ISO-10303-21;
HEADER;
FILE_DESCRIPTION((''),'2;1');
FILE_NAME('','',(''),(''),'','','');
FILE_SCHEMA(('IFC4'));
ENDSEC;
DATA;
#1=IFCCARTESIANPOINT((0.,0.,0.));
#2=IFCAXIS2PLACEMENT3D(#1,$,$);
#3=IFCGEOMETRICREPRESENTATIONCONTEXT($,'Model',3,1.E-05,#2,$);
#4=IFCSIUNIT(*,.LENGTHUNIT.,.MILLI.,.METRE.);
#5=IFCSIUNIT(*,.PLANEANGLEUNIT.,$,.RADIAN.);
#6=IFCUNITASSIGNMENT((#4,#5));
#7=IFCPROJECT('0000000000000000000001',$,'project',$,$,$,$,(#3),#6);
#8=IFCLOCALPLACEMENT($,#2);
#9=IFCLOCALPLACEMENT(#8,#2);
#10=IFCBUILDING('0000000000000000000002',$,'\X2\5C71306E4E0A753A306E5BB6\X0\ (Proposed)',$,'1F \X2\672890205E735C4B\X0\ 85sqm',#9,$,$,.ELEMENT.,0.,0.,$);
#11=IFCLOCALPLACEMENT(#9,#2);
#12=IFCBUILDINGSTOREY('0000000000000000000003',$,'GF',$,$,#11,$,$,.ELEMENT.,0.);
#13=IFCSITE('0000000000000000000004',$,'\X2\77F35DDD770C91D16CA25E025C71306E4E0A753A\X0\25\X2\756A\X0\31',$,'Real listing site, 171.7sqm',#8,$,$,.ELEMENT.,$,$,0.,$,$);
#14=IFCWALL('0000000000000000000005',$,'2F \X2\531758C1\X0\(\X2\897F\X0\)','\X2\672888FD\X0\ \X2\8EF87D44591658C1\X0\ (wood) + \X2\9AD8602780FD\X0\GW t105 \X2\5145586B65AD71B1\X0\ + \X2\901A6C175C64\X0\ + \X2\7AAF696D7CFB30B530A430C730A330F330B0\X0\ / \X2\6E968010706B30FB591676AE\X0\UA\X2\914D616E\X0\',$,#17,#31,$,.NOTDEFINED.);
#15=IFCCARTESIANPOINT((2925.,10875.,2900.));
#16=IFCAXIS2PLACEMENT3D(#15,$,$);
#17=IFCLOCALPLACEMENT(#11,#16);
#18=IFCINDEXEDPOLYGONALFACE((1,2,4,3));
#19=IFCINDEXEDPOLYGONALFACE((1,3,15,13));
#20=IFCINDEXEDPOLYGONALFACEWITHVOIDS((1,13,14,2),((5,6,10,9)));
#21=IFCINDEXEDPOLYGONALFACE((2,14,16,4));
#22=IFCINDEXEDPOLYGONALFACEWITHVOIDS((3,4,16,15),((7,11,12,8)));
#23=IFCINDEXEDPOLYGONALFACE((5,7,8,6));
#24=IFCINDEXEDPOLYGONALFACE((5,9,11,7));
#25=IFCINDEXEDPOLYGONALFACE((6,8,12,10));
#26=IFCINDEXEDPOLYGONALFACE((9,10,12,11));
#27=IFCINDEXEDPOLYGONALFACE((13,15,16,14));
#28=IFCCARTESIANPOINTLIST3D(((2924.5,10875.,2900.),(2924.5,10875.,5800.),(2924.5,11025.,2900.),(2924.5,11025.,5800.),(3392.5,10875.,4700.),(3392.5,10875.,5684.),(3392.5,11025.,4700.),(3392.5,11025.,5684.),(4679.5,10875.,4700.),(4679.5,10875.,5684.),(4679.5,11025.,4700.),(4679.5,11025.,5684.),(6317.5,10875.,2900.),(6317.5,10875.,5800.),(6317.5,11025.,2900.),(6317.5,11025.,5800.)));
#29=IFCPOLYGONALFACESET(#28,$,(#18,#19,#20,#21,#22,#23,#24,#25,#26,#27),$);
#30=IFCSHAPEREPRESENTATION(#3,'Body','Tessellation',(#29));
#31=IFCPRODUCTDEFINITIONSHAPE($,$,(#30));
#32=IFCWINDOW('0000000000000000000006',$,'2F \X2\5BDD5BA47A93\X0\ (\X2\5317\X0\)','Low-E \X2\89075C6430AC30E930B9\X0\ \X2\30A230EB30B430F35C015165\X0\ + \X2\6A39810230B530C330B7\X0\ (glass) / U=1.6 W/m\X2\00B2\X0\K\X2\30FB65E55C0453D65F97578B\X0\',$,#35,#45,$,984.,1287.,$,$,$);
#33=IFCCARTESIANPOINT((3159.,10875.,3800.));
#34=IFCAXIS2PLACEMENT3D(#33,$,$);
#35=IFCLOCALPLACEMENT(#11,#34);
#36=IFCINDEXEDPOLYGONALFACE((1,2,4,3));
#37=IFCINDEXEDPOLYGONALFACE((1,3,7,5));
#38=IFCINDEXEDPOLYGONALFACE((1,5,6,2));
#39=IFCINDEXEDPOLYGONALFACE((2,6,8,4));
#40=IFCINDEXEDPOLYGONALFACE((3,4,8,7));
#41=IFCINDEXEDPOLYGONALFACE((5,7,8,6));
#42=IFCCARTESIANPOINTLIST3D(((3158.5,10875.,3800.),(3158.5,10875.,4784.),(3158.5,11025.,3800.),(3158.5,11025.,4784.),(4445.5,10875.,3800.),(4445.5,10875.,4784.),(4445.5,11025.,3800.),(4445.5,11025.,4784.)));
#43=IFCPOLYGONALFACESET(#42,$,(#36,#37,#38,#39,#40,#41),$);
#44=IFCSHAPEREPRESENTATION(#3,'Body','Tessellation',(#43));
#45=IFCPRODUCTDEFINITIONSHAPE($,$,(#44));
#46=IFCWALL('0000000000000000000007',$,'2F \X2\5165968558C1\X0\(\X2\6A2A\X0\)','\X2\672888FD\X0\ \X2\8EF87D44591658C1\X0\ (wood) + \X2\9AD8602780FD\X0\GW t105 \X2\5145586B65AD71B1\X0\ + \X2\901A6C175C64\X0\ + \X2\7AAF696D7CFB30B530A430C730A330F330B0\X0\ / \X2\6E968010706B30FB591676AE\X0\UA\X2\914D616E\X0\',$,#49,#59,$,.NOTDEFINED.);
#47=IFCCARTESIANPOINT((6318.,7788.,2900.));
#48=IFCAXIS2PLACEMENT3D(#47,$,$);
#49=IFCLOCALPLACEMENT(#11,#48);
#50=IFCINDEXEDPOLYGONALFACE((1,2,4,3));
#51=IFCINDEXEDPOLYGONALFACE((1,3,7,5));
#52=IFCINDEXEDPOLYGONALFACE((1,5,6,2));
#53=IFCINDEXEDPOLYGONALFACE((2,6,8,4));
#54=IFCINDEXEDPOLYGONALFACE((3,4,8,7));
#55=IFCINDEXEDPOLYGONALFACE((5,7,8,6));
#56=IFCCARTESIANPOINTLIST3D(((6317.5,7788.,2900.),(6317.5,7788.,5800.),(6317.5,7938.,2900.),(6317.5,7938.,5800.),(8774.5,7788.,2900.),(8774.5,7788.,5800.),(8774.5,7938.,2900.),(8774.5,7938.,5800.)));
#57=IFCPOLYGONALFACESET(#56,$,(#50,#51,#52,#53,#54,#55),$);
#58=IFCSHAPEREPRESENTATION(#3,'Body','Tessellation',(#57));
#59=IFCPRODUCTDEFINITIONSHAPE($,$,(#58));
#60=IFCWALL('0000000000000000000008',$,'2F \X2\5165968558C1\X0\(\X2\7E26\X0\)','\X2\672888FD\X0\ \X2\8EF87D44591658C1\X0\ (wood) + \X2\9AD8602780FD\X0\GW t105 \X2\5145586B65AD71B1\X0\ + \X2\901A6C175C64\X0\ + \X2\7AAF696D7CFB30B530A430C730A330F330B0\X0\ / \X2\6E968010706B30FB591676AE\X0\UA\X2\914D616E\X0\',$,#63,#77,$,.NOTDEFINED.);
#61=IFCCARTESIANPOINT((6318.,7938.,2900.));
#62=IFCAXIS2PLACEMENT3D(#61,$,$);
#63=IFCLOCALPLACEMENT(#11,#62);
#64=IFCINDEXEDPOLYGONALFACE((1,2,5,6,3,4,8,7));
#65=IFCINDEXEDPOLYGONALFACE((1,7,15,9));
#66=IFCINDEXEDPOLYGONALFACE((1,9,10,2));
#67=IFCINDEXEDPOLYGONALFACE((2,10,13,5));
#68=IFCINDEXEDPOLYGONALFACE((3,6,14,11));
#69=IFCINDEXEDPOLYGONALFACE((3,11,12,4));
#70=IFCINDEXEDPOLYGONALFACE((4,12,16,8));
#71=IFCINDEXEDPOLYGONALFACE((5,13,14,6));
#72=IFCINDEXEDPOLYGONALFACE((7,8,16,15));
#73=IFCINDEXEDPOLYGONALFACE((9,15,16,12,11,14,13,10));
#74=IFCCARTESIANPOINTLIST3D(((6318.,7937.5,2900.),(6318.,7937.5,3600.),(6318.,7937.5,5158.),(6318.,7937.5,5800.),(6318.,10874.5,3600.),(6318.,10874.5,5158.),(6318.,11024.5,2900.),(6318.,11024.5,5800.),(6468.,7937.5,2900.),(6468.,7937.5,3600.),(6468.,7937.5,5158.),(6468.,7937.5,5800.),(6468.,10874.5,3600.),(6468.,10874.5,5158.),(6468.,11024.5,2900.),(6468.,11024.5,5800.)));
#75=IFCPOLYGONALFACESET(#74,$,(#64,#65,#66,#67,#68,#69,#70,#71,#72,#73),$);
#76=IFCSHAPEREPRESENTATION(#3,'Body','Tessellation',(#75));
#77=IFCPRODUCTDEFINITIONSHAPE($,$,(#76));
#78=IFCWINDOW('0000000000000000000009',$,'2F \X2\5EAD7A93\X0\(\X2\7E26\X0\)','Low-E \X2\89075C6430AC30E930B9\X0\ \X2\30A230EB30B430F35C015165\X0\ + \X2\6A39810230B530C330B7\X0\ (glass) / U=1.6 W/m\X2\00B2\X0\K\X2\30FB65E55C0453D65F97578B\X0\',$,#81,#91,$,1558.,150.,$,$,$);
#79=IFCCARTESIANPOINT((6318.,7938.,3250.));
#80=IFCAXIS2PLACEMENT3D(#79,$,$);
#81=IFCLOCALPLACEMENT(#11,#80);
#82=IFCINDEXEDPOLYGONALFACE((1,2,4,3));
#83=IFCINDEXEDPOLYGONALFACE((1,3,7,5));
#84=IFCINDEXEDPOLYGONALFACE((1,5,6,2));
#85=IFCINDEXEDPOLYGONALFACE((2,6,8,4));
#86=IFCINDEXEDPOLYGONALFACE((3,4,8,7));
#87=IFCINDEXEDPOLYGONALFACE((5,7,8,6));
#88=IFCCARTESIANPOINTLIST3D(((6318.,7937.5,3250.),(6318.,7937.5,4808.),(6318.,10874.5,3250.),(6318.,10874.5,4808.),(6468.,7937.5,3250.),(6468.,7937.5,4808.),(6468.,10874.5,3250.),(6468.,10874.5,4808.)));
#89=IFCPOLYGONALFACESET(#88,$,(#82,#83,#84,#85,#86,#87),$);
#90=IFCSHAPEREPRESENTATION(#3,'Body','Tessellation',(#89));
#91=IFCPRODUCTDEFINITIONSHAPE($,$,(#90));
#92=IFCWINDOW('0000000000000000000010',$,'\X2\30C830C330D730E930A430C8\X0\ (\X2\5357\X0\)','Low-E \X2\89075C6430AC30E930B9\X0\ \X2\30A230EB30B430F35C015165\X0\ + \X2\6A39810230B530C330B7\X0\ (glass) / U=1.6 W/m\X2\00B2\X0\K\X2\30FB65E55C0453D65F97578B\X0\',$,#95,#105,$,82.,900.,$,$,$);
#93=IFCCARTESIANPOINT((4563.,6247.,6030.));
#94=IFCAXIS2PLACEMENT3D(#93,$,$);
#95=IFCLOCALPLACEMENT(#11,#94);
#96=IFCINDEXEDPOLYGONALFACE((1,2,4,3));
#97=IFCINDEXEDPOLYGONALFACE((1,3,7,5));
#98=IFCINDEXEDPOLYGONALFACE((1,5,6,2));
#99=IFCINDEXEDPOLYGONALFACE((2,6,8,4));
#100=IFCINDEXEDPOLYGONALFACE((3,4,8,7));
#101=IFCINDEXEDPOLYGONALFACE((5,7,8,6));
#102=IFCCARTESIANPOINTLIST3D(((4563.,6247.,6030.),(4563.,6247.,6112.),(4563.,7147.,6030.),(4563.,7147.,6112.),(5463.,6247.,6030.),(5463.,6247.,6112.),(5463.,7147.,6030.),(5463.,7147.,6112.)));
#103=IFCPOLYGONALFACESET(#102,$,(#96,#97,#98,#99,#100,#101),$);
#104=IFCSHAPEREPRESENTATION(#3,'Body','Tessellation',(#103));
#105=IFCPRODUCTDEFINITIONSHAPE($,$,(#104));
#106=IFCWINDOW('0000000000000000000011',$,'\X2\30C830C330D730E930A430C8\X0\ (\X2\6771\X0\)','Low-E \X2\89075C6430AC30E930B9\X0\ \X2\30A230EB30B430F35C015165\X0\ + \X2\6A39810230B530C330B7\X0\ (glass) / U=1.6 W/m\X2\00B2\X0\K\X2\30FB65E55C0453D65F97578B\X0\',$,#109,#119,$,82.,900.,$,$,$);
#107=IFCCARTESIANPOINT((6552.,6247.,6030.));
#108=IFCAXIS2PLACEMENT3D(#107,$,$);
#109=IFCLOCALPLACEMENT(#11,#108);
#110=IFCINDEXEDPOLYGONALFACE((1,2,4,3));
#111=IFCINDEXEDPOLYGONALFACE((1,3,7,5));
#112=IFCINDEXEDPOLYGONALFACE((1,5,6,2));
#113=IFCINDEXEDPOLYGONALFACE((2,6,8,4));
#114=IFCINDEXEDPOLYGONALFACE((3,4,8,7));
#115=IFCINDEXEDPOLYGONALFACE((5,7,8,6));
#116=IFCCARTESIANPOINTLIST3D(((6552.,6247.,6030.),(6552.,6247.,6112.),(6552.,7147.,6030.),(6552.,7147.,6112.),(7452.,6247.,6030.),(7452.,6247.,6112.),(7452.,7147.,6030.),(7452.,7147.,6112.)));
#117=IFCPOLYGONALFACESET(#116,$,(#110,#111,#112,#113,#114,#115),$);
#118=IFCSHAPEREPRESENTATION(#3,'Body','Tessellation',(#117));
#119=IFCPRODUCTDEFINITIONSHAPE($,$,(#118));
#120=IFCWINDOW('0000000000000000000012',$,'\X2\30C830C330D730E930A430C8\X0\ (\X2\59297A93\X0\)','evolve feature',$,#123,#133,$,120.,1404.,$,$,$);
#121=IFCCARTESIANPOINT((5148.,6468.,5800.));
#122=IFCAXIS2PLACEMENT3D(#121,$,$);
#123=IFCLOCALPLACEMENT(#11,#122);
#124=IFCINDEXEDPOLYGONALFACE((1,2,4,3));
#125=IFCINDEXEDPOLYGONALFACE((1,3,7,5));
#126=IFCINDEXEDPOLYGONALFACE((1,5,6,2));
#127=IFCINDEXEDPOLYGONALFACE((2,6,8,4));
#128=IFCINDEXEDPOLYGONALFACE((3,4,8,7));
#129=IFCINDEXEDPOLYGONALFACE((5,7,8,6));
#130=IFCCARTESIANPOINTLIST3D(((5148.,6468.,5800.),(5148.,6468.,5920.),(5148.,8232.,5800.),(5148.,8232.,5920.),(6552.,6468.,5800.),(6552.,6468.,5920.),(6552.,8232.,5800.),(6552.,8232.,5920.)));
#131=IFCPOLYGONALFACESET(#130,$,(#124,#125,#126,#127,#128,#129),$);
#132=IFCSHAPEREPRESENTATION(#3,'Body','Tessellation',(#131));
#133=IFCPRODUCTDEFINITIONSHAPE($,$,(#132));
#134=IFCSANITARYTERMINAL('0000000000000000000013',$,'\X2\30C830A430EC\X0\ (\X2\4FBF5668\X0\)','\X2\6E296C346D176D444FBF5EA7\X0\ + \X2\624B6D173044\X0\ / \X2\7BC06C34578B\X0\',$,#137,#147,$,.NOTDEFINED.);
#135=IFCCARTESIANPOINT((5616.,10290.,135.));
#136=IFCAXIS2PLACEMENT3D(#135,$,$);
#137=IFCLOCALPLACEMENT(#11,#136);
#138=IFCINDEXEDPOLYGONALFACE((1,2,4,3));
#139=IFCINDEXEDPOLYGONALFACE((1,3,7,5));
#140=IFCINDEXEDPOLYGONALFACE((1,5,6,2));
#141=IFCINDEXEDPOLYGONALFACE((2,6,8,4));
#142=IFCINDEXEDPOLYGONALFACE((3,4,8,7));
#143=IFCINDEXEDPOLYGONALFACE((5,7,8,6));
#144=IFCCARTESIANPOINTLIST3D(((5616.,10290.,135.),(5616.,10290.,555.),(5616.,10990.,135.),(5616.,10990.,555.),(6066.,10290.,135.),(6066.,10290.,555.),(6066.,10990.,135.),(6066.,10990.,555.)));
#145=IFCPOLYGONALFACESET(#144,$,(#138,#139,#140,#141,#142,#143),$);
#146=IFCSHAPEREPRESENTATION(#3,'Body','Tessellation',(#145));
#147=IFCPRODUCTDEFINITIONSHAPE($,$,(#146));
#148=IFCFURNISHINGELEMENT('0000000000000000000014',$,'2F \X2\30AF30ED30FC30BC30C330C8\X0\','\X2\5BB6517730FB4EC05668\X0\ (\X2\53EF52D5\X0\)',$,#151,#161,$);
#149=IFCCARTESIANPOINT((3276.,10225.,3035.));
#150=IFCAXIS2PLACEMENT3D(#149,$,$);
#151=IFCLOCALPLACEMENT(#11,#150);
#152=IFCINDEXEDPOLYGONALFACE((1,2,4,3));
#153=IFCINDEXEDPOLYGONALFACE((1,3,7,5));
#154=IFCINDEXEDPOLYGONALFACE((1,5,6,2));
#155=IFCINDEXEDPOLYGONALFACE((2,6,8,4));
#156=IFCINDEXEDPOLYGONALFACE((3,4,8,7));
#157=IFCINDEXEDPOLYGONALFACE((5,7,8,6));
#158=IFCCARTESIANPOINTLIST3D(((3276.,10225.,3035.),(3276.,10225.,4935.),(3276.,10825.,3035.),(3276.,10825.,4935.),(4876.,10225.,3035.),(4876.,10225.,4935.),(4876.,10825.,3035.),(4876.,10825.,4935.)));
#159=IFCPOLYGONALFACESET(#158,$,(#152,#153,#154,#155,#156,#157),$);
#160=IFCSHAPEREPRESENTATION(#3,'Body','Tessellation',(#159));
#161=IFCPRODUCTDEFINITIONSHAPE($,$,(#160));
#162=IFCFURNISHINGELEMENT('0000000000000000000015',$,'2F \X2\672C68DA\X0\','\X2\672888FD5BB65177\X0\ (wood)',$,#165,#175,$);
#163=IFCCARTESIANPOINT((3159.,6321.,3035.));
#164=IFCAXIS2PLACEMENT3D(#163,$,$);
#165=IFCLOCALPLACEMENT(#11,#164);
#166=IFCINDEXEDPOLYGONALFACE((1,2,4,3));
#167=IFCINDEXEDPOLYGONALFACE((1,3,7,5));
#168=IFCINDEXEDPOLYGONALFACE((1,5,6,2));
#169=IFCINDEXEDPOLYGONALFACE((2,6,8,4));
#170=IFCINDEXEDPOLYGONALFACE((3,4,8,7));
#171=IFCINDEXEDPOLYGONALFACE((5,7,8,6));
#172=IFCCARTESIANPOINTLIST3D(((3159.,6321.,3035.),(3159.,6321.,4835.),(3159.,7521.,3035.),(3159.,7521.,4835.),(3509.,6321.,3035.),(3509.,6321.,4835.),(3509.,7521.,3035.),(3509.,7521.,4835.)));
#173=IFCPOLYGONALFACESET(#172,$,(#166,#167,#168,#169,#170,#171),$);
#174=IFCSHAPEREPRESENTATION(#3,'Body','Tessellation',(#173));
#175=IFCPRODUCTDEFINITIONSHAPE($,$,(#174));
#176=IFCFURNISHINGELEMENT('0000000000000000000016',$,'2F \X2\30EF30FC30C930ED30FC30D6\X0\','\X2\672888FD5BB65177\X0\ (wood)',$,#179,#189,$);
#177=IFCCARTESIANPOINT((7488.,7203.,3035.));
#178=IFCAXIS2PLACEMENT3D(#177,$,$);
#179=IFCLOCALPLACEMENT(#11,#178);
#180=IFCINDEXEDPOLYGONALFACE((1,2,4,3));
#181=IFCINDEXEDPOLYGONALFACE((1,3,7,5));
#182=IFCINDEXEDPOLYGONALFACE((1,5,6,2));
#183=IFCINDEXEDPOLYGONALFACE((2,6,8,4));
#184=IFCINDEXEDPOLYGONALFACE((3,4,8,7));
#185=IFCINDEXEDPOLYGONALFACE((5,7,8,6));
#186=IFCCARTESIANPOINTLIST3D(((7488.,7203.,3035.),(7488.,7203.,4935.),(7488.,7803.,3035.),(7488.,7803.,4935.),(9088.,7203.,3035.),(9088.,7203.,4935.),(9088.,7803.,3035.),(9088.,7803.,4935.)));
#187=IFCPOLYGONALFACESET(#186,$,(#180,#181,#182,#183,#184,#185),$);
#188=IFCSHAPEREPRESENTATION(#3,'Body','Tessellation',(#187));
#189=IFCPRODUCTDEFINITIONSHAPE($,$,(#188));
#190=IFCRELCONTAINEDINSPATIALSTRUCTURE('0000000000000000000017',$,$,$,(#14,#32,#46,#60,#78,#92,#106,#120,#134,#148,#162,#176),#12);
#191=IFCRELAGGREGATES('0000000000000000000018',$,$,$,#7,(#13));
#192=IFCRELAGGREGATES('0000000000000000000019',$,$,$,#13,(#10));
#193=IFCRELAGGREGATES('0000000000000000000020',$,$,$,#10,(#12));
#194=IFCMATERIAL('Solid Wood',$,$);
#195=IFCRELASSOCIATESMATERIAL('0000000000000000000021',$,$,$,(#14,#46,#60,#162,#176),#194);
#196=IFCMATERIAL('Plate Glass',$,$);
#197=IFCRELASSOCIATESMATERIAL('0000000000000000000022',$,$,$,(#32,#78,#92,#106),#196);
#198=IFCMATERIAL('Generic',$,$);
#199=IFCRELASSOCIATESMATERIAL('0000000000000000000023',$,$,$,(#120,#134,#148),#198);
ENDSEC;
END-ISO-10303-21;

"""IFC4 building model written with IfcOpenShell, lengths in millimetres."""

from ifc_helpers import new_model, si_unit, frame, frame_2d, origin, place, context, project, spatial, rectangle, extrude, material, element, fill, save


model = new_model("IFC4")

# Units and contexts
model_context = context("Model", 3, precision=1e-05, world=origin())
ifc_project = project(units=[si_unit("LENGTHUNIT", "METRE", prefix="MILLI"), si_unit("PLANEANGLEUNIT", "RADIAN")], contexts=[model_context])

# Site, building, storey
site_placement = place(None, origin())
site = spatial("IfcSite", under=ifc_project, at=site_placement, Name="石川県金沢市山の上町25番31", ObjectType="Real listing site, 171.7sqm", CompositionType="ELEMENT", RefElevation=0.0)
building_placement = place(site_placement, origin())
building = spatial("IfcBuilding", under=site, at=building_placement, Name="山の上町の家 (Proposed)", ObjectType="1F 木造平屋 85sqm", CompositionType="ELEMENT", ElevationOfRefHeight=0.0, ElevationOfTerrain=0.0)
storey_placement = place(building_placement, origin())
storey = spatial("IfcBuildingStorey", under=building, at=storey_placement, Name="GF", CompositionType="ELEMENT", Elevation=0.0)

# Shared definitions
ifc_material_1 = material(Name="Solid Wood")

# Wall, opening, window
wall_1_placement = place(storey_placement, frame((2925.0, 10875.0, 2900.0)))
wall_1 = element("IfcWall", 1, at=wall_1_placement, inside=storey, material=ifc_material_1, Name="2F 北壁(西)", Description="木製 軸組外壁 (wood) + 高性能GW t105 充填断熱 + 通気層 + 窯業系サイディング / 準耐火・外皮UA配慮", PredefinedType="NOTDEFINED", context=model_context, shape_type="SweptSolid", body=[
    extrude(rectangle(XDim=3393.0, YDim=150.0, at=frame_2d((1696.0, 75.0))), frame((2925.0, 10875.0, 2900.0)), (0.0, 0.0, 1.0), 2900.0),
])
opening_1_placement = place(storey_placement, frame((3159.0, 10875.0, 3800.0)))
opening_1 = element("IfcOpeningElement", 2, at=opening_1_placement, cuts=wall_1, PredefinedType="NOTDEFINED", context=model_context, shape_type="SweptSolid", body=[
    extrude(rectangle(XDim=1287.0, YDim=150.0, at=frame_2d((643.0, 75.0))), frame((3159.0, 10875.0, 3800.0)), (0.0, 0.0, 1.0), 984.0),
])
ifc_material_2 = material(Name="Plate Glass")
window_1_placement = place(storey_placement, frame((3159.0, 10875.0, 3800.0)))
window_1 = element("IfcWindow", 3, at=window_1_placement, inside=storey, material=ifc_material_2, Name="2F 寝室窓 (北)", Description="Low-E 複層ガラス アルゴン封入 + 樹脂サッシ (glass) / U=1.6 W/m²K・日射取得型", OverallHeight=984.0, OverallWidth=1287.0, context=model_context, shape_type="SweptSolid", body=[
    extrude(rectangle(XDim=1287.0, YDim=150.0, at=frame_2d((643.0, 75.0))), frame((3159.0, 10875.0, 3800.0)), (0.0, 0.0, 1.0), 984.0),
])
fill(opening_1, window_1)

# Wall
wall_2_placement = place(storey_placement, frame((6318.0, 7788.0, 2900.0)))
element("IfcWall", 4, at=wall_2_placement, inside=storey, material=ifc_material_1, Name="2F 入隅壁(横)", Description="木製 軸組外壁 (wood) + 高性能GW t105 充填断熱 + 通気層 + 窯業系サイディング / 準耐火・外皮UA配慮", PredefinedType="NOTDEFINED", context=model_context, shape_type="SweptSolid", body=[
    extrude(rectangle(XDim=2457.0, YDim=150.0, at=frame_2d((1228.0, 75.0))), frame((6318.0, 7788.0, 2900.0)), (0.0, 0.0, 1.0), 2900.0),
])

# Wall, opening, window
wall_3_placement = place(storey_placement, frame((6318.0, 7938.0, 2900.0)))
wall_3 = element("IfcWall", 5, at=wall_3_placement, inside=storey, material=ifc_material_1, Name="2F 入隅壁(縦)", Description="木製 軸組外壁 (wood) + 高性能GW t105 充填断熱 + 通気層 + 窯業系サイディング / 準耐火・外皮UA配慮", PredefinedType="NOTDEFINED", context=model_context, shape_type="SweptSolid", body=[
    extrude(rectangle(XDim=150.0, YDim=3087.0, at=frame_2d((75.0, 1543.0))), frame((6318.0, 7938.0, 2900.0)), (0.0, 0.0, 1.0), 2900.0),
])
opening_2_placement = place(storey_placement, frame((6318.0, 7938.0, 3250.0)))
opening_2 = element("IfcOpeningElement", 6, at=opening_2_placement, cuts=wall_3, PredefinedType="NOTDEFINED", context=model_context, shape_type="SweptSolid", body=[
    extrude(rectangle(XDim=150.0, YDim=2937.0, at=frame_2d((75.0, 1468.0))), frame((6318.0, 7938.0, 3250.0)), (0.0, 0.0, 1.0), 1558.0),
])
window_2_placement = place(storey_placement, frame((6318.0, 7938.0, 3250.0)))
window_2 = element("IfcWindow", 7, at=window_2_placement, inside=storey, material=ifc_material_2, Name="2F 庭窓(縦)", Description="Low-E 複層ガラス アルゴン封入 + 樹脂サッシ (glass) / U=1.6 W/m²K・日射取得型", OverallHeight=1558.0, OverallWidth=150.0, context=model_context, shape_type="SweptSolid", body=[
    extrude(rectangle(XDim=150.0, YDim=2937.0, at=frame_2d((75.0, 1468.0))), frame((6318.0, 7938.0, 3250.0)), (0.0, 0.0, 1.0), 1558.0),
])
fill(opening_2, window_2)

# Windows
window_3_placement = place(storey_placement, frame((4563.0, 6247.0, 6030.0)))
element("IfcWindow", 8, at=window_3_placement, inside=storey, material=ifc_material_2, Name="トップライト (南)", Description="Low-E 複層ガラス アルゴン封入 + 樹脂サッシ (glass) / U=1.6 W/m²K・日射取得型", OverallHeight=82.0, OverallWidth=900.0, context=model_context, shape_type="SweptSolid", body=[
    extrude(rectangle(XDim=900.0, YDim=900.0, at=frame_2d((450.0, 450.0))), frame((4563.0, 6247.0, 6030.0)), (0.0, 0.0, 1.0), 82.0),
])
window_4_placement = place(storey_placement, frame((6552.0, 6247.0, 6030.0)))
element("IfcWindow", 9, at=window_4_placement, inside=storey, material=ifc_material_2, Name="トップライト (東)", Description="Low-E 複層ガラス アルゴン封入 + 樹脂サッシ (glass) / U=1.6 W/m²K・日射取得型", OverallHeight=82.0, OverallWidth=900.0, context=model_context, shape_type="SweptSolid", body=[
    extrude(rectangle(XDim=900.0, YDim=900.0, at=frame_2d((450.0, 450.0))), frame((6552.0, 6247.0, 6030.0)), (0.0, 0.0, 1.0), 82.0),
])
ifc_material_3 = material(Name="Generic")
window_5_placement = place(storey_placement, frame((5148.0, 6468.0, 5800.0)))
element("IfcWindow", 10, at=window_5_placement, inside=storey, material=ifc_material_3, Name="トップライト (天窓)", Description="evolve feature", OverallHeight=120.0, OverallWidth=1404.0, context=model_context, shape_type="SweptSolid", body=[
    extrude(rectangle(XDim=1404.0, YDim=1764.0, at=frame_2d((702.0, 882.0))), frame((5148.0, 6468.0, 5800.0)), (0.0, 0.0, 1.0), 120.0),
])

# Sanitary terminal
sanitary_terminal_placement = place(storey_placement, frame((5616.0, 10290.0, 135.0)))
element("IfcSanitaryTerminal", 11, at=sanitary_terminal_placement, inside=storey, material=ifc_material_3, Name="トイレ (便器)", Description="温水洗浄便座 + 手洗い / 節水型", PredefinedType="NOTDEFINED", context=model_context, shape_type="SweptSolid", body=[
    extrude(rectangle(XDim=450.0, YDim=700.0, at=frame_2d((225.0, 350.0))), frame((5616.0, 10290.0, 135.0)), (0.0, 0.0, 1.0), 420.0),
])

# Furnishing elements
furnishing_1_placement = place(storey_placement, frame((3276.0, 10225.0, 3035.0)))
element("IfcFurnishingElement", 12, at=furnishing_1_placement, inside=storey, material=ifc_material_3, Name="2F クローゼット", Description="家具・什器 (可動)", context=model_context, shape_type="SweptSolid", body=[
    extrude(rectangle(XDim=1600.0, YDim=600.0, at=frame_2d((800.0, 300.0))), frame((3276.0, 10225.0, 3035.0)), (0.0, 0.0, 1.0), 1900.0),
])
furnishing_2_placement = place(storey_placement, frame((3159.0, 6321.0, 3035.0)))
element("IfcFurnishingElement", 13, at=furnishing_2_placement, inside=storey, material=ifc_material_1, Name="2F 本棚", Description="木製家具 (wood)", context=model_context, shape_type="SweptSolid", body=[
    extrude(rectangle(XDim=350.0, YDim=1200.0, at=frame_2d((175.0, 600.0))), frame((3159.0, 6321.0, 3035.0)), (0.0, 0.0, 1.0), 1800.0),
])
furnishing_3_placement = place(storey_placement, frame((7488.0, 7203.0, 3035.0)))
element("IfcFurnishingElement", 14, at=furnishing_3_placement, inside=storey, material=ifc_material_1, Name="2F ワードローブ", Description="木製家具 (wood)", context=model_context, shape_type="SweptSolid", body=[
    extrude(rectangle(XDim=1600.0, YDim=600.0, at=frame_2d((800.0, 300.0))), frame((7488.0, 7203.0, 3035.0)), (0.0, 0.0, 1.0), 1900.0),
])

save(model, "model.ifc")
